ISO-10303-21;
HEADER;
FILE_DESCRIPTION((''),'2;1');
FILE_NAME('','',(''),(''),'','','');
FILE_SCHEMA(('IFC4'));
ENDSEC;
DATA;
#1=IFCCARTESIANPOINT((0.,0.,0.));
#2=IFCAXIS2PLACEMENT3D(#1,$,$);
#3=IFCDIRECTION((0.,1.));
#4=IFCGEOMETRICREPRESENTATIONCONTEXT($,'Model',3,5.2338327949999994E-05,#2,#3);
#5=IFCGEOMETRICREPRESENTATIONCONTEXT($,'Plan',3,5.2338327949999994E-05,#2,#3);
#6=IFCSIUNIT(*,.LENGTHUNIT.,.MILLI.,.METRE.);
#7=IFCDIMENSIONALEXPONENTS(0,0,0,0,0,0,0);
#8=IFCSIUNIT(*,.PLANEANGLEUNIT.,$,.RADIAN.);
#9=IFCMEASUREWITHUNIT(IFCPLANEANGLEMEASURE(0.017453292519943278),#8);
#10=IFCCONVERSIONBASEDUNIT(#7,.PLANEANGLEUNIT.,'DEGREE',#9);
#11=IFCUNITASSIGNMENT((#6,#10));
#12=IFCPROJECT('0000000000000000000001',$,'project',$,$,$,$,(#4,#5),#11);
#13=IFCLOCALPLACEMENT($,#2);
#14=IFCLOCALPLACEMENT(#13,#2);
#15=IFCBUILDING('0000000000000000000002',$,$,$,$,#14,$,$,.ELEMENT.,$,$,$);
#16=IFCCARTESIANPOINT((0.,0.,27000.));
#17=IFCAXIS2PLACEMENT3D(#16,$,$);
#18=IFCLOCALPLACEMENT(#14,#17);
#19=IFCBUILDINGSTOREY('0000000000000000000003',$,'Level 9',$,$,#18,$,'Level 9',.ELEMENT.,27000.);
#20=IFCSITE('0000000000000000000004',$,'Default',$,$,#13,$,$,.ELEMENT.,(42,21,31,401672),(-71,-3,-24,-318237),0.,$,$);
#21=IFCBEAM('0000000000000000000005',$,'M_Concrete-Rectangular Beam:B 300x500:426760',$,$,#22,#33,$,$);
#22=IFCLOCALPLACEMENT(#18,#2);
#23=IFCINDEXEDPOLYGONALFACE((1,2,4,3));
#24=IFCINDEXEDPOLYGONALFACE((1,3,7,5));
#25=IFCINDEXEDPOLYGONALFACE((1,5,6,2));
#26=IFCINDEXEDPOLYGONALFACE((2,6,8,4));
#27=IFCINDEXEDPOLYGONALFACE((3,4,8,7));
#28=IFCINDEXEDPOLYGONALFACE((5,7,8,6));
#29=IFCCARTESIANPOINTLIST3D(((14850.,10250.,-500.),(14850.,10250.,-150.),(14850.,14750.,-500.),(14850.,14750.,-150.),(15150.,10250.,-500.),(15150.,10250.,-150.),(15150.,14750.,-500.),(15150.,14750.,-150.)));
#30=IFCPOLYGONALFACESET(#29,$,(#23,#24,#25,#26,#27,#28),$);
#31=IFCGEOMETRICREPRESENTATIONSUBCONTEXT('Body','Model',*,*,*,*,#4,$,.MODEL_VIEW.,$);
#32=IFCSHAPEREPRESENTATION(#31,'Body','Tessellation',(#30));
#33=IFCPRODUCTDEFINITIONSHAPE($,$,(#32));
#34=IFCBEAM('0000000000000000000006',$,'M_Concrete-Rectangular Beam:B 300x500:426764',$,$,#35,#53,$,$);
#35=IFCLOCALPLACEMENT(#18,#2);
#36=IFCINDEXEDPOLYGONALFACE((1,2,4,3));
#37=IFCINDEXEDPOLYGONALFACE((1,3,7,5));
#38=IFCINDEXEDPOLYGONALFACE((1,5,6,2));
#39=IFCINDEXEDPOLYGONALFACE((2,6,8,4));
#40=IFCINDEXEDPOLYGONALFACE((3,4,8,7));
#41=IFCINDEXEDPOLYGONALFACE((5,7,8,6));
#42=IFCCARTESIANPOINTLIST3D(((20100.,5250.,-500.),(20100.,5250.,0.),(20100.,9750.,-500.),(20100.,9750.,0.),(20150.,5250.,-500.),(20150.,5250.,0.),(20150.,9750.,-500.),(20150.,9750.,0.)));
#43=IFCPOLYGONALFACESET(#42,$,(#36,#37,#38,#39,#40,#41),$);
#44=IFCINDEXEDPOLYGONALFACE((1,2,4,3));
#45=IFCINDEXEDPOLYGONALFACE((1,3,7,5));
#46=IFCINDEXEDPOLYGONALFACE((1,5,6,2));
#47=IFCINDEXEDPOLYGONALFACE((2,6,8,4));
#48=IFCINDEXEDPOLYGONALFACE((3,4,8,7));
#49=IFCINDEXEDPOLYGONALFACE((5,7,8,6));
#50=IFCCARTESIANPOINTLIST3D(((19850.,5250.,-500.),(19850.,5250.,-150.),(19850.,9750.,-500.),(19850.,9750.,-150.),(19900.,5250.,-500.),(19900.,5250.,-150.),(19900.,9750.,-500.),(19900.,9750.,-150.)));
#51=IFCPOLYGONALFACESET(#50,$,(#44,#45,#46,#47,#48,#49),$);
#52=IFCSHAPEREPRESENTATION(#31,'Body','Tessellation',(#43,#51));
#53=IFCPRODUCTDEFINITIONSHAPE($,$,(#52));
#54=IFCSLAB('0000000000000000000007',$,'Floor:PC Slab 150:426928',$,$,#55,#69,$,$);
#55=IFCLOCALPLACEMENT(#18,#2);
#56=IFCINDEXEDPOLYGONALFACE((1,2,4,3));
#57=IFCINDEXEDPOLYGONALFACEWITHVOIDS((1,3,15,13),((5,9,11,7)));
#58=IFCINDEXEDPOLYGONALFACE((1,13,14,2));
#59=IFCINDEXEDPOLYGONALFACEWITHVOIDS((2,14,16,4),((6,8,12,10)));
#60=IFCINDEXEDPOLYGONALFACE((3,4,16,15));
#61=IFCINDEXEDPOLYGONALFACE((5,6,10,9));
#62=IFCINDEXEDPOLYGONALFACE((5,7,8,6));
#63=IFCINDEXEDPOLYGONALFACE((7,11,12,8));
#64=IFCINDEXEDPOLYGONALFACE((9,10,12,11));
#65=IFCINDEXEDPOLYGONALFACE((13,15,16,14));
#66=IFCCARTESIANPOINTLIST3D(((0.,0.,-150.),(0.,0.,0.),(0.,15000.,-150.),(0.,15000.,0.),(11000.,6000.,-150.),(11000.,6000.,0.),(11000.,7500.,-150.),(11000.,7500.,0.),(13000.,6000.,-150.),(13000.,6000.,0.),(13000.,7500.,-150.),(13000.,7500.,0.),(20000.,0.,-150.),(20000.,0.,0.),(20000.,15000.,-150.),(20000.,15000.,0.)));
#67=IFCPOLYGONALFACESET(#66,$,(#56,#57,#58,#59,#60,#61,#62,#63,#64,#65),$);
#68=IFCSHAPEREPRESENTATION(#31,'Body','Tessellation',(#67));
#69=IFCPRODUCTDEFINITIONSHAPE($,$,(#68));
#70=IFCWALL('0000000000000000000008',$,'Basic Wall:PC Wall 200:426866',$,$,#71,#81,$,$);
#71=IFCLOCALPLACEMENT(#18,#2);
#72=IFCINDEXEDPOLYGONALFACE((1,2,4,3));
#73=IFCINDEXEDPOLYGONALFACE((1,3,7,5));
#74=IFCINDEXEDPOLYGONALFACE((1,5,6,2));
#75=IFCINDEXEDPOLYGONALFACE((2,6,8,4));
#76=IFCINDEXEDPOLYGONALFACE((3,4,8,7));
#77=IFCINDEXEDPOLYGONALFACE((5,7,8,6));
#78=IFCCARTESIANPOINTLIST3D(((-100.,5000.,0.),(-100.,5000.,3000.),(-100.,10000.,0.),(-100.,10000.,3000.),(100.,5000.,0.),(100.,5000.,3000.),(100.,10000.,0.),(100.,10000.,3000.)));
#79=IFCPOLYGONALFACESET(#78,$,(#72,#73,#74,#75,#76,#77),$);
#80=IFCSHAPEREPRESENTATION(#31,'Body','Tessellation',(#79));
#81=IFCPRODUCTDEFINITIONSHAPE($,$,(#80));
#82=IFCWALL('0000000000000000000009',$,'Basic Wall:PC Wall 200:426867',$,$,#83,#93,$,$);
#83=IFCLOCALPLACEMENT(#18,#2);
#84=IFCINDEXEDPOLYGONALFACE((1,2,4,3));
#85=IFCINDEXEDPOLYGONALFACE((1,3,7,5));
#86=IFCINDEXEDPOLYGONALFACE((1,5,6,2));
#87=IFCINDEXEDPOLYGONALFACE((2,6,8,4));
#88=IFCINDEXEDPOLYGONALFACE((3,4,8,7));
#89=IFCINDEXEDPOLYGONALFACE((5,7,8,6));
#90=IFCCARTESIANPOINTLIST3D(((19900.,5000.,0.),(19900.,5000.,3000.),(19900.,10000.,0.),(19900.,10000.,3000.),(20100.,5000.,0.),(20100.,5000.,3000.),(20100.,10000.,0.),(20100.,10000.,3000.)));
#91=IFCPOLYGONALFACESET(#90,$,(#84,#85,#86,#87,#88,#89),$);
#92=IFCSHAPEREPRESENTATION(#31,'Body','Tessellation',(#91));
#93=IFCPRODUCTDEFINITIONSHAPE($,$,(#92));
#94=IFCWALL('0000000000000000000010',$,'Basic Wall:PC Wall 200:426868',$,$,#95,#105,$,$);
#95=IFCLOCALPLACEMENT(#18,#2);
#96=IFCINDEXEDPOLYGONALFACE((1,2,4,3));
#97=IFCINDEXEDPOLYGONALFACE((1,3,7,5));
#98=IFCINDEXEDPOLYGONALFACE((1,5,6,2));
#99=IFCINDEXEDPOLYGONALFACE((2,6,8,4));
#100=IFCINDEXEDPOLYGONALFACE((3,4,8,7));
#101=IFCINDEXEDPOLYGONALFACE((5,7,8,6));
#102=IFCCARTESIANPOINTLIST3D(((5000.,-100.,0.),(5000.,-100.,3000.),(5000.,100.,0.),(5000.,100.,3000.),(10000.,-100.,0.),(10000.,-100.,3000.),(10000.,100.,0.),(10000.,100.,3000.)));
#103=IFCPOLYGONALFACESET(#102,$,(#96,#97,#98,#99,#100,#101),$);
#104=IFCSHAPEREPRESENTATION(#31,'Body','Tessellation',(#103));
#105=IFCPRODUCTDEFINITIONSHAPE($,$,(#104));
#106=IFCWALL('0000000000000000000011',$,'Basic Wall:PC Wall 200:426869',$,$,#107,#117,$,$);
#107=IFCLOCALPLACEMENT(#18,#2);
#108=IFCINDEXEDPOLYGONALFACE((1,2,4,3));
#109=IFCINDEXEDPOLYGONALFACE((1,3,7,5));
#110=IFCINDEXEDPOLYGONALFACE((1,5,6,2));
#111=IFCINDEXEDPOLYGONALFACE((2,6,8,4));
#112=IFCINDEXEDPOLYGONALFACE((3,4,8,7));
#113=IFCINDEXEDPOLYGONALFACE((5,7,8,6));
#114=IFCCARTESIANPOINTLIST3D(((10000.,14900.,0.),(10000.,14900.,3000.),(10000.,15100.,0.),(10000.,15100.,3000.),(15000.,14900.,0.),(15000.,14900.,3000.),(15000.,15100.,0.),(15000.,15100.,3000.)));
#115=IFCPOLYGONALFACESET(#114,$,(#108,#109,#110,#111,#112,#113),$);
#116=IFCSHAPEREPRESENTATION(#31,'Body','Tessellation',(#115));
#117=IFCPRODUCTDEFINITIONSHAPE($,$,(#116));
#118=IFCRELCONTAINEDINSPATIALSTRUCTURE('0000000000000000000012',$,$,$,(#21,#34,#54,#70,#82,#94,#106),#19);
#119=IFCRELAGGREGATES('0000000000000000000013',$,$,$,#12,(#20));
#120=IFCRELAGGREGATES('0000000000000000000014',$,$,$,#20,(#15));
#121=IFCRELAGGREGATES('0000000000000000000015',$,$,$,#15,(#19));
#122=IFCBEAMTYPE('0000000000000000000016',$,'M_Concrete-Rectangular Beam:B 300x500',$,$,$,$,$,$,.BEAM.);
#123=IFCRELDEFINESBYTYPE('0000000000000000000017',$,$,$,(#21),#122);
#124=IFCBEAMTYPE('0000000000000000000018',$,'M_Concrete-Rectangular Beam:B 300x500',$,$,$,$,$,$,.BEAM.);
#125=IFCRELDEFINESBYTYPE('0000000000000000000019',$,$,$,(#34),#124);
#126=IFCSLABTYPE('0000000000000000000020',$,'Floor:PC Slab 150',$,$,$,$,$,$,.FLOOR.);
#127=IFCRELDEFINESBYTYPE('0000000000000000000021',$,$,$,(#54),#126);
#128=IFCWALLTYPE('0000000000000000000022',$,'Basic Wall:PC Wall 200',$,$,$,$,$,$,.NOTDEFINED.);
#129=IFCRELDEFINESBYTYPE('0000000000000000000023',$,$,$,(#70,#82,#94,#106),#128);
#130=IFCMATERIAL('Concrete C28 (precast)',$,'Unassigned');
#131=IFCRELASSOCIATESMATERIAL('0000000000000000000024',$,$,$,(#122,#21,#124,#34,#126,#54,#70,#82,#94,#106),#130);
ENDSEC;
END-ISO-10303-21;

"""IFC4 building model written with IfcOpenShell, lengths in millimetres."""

from ifc_helpers import new_model, entity, si_unit, converted_unit, direction, frame, origin, place, context, subcontext, project, spatial, indexed_curve, outline, extrude, source, transform, mapped, material, type_object, type_shapes, element, save


model = new_model("IFC4")

# Units and contexts
model_context = context("Model", 3, precision=5.2338327949999994e-05, world=origin(), true_north=direction((0.0, 1.0)))
plan_context = context("Plan", 3, precision=5.2338327949999994e-05, world=origin(), true_north=direction((0.0, 1.0)))
body_context = subcontext(model_context, "Body", "Model", "MODEL_VIEW")
ifc_project = project(units=[si_unit("LENGTHUNIT", "METRE", prefix="MILLI"), converted_unit("PLANEANGLEUNIT", "DEGREE", entity("IfcPlaneAngleMeasure", 0.017453292519943278), si_unit("PLANEANGLEUNIT", "RADIAN"), dimensions=[0, 0, 0, 0, 0, 0, 0])], contexts=[model_context, plan_context])

# Site, building, storey
site_placement = place(None, origin())
site = spatial("IfcSite", under=ifc_project, at=site_placement, Name="Default", CompositionType="ELEMENT", RefLatitude=(42, 21, 31, 401672), RefLongitude=(-71, -3, -24, -318237), RefElevation=0.0)
building_placement = place(site_placement, origin())
building = spatial("IfcBuilding", under=site, at=building_placement, CompositionType="ELEMENT")
storey_placement = place(building_placement, frame((0.0, 0.0, 27000.0)))
storey = spatial("IfcBuildingStorey", under=building, at=storey_placement, Name="Level 9", LongName="Level 9", CompositionType="ELEMENT", Elevation=27000.0)

# Beams
ifc_material = material(Name="Concrete C28 (precast)", Category="Unassigned")
beam_type_1 = type_object("IfcBeamType", Name="M_Concrete-Rectangular Beam:B 300x500", PredefinedType="BEAM", material=ifc_material)
shared_shape_1 = source(origin(), body_context, "Body", "SweptSolid", [
    extrude(outline(indexed_curve([(-150.0, -175.0), (150.0, -175.0), (150.0, 175.0), (-150.0, 175.0), (-150.0, -175.0)], self_intersect=False)), frame((15000.0, 10250.0, 26675.0), z_axis=(0.0, 1.0, 0.0), x_axis=(-1.0, 0.0, 0.0)), (0.0, 0.0, 1.0), 4500.0),
])
type_shapes(beam_type_1, [shared_shape_1])
beam_1_placement = place(storey_placement, frame((0.0, 0.0, -27000.0)))
element("IfcBeam", 1, at=beam_1_placement, inside=storey, type_object=beam_type_1, material=ifc_material, Name="M_Concrete-Rectangular Beam:B 300x500:426760", context=body_context, shape_type="MappedRepresentation", body=[
    mapped(shared_shape_1, transform((0.0, 0.0, 0.0), scale=1.0)),
])
beam_type_2 = type_object("IfcBeamType", Name="M_Concrete-Rectangular Beam:B 300x500", PredefinedType="BEAM", material=ifc_material)
shared_shape_2 = source(origin(), body_context, "Body", "SweptSolid", [
    extrude(outline(indexed_curve([(-25.0, -250.0), (25.0, -250.0), (25.0, 250.0), (-25.0, 250.0), (-25.0, -250.0)], self_intersect=False)), frame((20125.0, 5250.0, 26750.0), z_axis=(0.0, 1.0, 0.0), x_axis=(-1.0, 0.0, 0.0)), (0.0, 0.0, 1.0), 4500.0),
    extrude(outline(indexed_curve([(-25.0, -175.0), (25.0, -175.0), (25.0, 175.0), (-25.0, 175.0), (-25.0, -175.0)], self_intersect=False)), frame((19875.0, 5250.0, 26675.0), z_axis=(0.0, 1.0, 0.0), x_axis=(-1.0, 0.0, 0.0)), (0.0, 0.0, 1.0), 4500.0),
])
type_shapes(beam_type_2, [shared_shape_2])
beam_2_placement = place(storey_placement, frame((0.0, 0.0, -27000.0)))
element("IfcBeam", 2, at=beam_2_placement, inside=storey, type_object=beam_type_2, material=ifc_material, Name="M_Concrete-Rectangular Beam:B 300x500:426764", context=body_context, shape_type="MappedRepresentation", body=[
    mapped(shared_shape_2, transform((0.0, 0.0, 0.0), scale=1.0)),
])

# Slab, opening
slab_type = type_object("IfcSlabType", Name="Floor:PC Slab 150", PredefinedType="FLOOR", material=ifc_material)
slab_placement = place(storey_placement, origin())
slab = element("IfcSlab", 3, at=slab_placement, inside=storey, type_object=slab_type, material=ifc_material, Name="Floor:PC Slab 150:426928", context=body_context, shape_type="SweptSolid", body=[
    extrude(outline(indexed_curve([(-7500.0, -10000.0), (7500.0, -10000.0), (7500.0, 10000.0), (-7500.0, 10000.0), (-7500.0, -10000.0)], self_intersect=False), holes=[indexed_curve([(-1500.0, -3000.0), (-1500.0, -1000.0), (0.0, -1000.0), (0.0, -3000.0), (-1500.0, -3000.0)], self_intersect=False)]), frame((10000.0, 7500.0, -150.0), z_axis=(0.0, 0.0, 1.0), x_axis=(0.0, 1.0, 0.0)), (0.0, 0.0, 1.0), 150.0),
])
opening_placement = place(slab_placement, origin())
element("IfcOpeningElement", 4, at=opening_placement, cuts=slab, PredefinedType="OPENING", context=body_context, shape_type="SweptSolid", body=[
    extrude(outline(indexed_curve([(13000.0, 6000.0), (13000.0, 7500.0), (11000.0, 7500.0), (11000.0, 6000.0), (13000.0, 6000.0)], self_intersect=False)), frame((0.0, 0.0, -27000.0)), (0.0, 0.0, 1.0), 20000.0),
])

# Walls
wall_type = type_object("IfcWallType", Name="Basic Wall:PC Wall 200", PredefinedType="NOTDEFINED")
wall_1_placement = place(storey_placement, frame((0.0, 5000.0, 0.0), z_axis=(0.0, 0.0, 1.0), x_axis=(0.0, 1.0, 0.0)))
element("IfcWall", 5, at=wall_1_placement, inside=storey, type_object=wall_type, material=ifc_material, Name="Basic Wall:PC Wall 200:426866", context=body_context, shape_type="SweptSolid", body=[
    extrude(outline(indexed_curve([(5000.0, 100.0), (0.0, 100.0), (0.0, -100.0), (5000.0, -100.0), (5000.0, 100.0)], self_intersect=False)), origin(), (0.0, 0.0, 1.0), 3000.0),
])
wall_2_placement = place(storey_placement, frame((20000.0, 5000.0, 0.0), z_axis=(0.0, 0.0, 1.0), x_axis=(0.0, 1.0, 0.0)))
element("IfcWall", 6, at=wall_2_placement, inside=storey, type_object=wall_type, material=ifc_material, Name="Basic Wall:PC Wall 200:426867", context=body_context, shape_type="SweptSolid", body=[
    extrude(outline(indexed_curve([(5000.0, 100.0), (0.0, 100.0), (0.0, -100.0), (5000.0, -100.0), (5000.0, 100.0)], self_intersect=False)), origin(), (0.0, 0.0, 1.0), 3000.0),
])
wall_3_placement = place(storey_placement, frame((5000.0, 0.0, 0.0)))
element("IfcWall", 7, at=wall_3_placement, inside=storey, type_object=wall_type, material=ifc_material, Name="Basic Wall:PC Wall 200:426868", context=body_context, shape_type="SweptSolid", body=[
    extrude(outline(indexed_curve([(5000.0, 100.0), (0.0, 100.0), (0.0, -100.0), (5000.0, -100.0), (5000.0, 100.0)], self_intersect=False)), origin(), (0.0, 0.0, 1.0), 3000.0),
])
wall_4_placement = place(storey_placement, frame((10000.0, 15000.0, 0.0)))
element("IfcWall", 8, at=wall_4_placement, inside=storey, type_object=wall_type, material=ifc_material, Name="Basic Wall:PC Wall 200:426869", context=body_context, shape_type="SweptSolid", body=[
    extrude(outline(indexed_curve([(5000.0, 100.0), (0.0, 100.0), (0.0, -100.0), (5000.0, -100.0), (5000.0, 100.0)], self_intersect=False)), origin(), (0.0, 0.0, 1.0), 3000.0),
])

save(model, "model.ifc")
